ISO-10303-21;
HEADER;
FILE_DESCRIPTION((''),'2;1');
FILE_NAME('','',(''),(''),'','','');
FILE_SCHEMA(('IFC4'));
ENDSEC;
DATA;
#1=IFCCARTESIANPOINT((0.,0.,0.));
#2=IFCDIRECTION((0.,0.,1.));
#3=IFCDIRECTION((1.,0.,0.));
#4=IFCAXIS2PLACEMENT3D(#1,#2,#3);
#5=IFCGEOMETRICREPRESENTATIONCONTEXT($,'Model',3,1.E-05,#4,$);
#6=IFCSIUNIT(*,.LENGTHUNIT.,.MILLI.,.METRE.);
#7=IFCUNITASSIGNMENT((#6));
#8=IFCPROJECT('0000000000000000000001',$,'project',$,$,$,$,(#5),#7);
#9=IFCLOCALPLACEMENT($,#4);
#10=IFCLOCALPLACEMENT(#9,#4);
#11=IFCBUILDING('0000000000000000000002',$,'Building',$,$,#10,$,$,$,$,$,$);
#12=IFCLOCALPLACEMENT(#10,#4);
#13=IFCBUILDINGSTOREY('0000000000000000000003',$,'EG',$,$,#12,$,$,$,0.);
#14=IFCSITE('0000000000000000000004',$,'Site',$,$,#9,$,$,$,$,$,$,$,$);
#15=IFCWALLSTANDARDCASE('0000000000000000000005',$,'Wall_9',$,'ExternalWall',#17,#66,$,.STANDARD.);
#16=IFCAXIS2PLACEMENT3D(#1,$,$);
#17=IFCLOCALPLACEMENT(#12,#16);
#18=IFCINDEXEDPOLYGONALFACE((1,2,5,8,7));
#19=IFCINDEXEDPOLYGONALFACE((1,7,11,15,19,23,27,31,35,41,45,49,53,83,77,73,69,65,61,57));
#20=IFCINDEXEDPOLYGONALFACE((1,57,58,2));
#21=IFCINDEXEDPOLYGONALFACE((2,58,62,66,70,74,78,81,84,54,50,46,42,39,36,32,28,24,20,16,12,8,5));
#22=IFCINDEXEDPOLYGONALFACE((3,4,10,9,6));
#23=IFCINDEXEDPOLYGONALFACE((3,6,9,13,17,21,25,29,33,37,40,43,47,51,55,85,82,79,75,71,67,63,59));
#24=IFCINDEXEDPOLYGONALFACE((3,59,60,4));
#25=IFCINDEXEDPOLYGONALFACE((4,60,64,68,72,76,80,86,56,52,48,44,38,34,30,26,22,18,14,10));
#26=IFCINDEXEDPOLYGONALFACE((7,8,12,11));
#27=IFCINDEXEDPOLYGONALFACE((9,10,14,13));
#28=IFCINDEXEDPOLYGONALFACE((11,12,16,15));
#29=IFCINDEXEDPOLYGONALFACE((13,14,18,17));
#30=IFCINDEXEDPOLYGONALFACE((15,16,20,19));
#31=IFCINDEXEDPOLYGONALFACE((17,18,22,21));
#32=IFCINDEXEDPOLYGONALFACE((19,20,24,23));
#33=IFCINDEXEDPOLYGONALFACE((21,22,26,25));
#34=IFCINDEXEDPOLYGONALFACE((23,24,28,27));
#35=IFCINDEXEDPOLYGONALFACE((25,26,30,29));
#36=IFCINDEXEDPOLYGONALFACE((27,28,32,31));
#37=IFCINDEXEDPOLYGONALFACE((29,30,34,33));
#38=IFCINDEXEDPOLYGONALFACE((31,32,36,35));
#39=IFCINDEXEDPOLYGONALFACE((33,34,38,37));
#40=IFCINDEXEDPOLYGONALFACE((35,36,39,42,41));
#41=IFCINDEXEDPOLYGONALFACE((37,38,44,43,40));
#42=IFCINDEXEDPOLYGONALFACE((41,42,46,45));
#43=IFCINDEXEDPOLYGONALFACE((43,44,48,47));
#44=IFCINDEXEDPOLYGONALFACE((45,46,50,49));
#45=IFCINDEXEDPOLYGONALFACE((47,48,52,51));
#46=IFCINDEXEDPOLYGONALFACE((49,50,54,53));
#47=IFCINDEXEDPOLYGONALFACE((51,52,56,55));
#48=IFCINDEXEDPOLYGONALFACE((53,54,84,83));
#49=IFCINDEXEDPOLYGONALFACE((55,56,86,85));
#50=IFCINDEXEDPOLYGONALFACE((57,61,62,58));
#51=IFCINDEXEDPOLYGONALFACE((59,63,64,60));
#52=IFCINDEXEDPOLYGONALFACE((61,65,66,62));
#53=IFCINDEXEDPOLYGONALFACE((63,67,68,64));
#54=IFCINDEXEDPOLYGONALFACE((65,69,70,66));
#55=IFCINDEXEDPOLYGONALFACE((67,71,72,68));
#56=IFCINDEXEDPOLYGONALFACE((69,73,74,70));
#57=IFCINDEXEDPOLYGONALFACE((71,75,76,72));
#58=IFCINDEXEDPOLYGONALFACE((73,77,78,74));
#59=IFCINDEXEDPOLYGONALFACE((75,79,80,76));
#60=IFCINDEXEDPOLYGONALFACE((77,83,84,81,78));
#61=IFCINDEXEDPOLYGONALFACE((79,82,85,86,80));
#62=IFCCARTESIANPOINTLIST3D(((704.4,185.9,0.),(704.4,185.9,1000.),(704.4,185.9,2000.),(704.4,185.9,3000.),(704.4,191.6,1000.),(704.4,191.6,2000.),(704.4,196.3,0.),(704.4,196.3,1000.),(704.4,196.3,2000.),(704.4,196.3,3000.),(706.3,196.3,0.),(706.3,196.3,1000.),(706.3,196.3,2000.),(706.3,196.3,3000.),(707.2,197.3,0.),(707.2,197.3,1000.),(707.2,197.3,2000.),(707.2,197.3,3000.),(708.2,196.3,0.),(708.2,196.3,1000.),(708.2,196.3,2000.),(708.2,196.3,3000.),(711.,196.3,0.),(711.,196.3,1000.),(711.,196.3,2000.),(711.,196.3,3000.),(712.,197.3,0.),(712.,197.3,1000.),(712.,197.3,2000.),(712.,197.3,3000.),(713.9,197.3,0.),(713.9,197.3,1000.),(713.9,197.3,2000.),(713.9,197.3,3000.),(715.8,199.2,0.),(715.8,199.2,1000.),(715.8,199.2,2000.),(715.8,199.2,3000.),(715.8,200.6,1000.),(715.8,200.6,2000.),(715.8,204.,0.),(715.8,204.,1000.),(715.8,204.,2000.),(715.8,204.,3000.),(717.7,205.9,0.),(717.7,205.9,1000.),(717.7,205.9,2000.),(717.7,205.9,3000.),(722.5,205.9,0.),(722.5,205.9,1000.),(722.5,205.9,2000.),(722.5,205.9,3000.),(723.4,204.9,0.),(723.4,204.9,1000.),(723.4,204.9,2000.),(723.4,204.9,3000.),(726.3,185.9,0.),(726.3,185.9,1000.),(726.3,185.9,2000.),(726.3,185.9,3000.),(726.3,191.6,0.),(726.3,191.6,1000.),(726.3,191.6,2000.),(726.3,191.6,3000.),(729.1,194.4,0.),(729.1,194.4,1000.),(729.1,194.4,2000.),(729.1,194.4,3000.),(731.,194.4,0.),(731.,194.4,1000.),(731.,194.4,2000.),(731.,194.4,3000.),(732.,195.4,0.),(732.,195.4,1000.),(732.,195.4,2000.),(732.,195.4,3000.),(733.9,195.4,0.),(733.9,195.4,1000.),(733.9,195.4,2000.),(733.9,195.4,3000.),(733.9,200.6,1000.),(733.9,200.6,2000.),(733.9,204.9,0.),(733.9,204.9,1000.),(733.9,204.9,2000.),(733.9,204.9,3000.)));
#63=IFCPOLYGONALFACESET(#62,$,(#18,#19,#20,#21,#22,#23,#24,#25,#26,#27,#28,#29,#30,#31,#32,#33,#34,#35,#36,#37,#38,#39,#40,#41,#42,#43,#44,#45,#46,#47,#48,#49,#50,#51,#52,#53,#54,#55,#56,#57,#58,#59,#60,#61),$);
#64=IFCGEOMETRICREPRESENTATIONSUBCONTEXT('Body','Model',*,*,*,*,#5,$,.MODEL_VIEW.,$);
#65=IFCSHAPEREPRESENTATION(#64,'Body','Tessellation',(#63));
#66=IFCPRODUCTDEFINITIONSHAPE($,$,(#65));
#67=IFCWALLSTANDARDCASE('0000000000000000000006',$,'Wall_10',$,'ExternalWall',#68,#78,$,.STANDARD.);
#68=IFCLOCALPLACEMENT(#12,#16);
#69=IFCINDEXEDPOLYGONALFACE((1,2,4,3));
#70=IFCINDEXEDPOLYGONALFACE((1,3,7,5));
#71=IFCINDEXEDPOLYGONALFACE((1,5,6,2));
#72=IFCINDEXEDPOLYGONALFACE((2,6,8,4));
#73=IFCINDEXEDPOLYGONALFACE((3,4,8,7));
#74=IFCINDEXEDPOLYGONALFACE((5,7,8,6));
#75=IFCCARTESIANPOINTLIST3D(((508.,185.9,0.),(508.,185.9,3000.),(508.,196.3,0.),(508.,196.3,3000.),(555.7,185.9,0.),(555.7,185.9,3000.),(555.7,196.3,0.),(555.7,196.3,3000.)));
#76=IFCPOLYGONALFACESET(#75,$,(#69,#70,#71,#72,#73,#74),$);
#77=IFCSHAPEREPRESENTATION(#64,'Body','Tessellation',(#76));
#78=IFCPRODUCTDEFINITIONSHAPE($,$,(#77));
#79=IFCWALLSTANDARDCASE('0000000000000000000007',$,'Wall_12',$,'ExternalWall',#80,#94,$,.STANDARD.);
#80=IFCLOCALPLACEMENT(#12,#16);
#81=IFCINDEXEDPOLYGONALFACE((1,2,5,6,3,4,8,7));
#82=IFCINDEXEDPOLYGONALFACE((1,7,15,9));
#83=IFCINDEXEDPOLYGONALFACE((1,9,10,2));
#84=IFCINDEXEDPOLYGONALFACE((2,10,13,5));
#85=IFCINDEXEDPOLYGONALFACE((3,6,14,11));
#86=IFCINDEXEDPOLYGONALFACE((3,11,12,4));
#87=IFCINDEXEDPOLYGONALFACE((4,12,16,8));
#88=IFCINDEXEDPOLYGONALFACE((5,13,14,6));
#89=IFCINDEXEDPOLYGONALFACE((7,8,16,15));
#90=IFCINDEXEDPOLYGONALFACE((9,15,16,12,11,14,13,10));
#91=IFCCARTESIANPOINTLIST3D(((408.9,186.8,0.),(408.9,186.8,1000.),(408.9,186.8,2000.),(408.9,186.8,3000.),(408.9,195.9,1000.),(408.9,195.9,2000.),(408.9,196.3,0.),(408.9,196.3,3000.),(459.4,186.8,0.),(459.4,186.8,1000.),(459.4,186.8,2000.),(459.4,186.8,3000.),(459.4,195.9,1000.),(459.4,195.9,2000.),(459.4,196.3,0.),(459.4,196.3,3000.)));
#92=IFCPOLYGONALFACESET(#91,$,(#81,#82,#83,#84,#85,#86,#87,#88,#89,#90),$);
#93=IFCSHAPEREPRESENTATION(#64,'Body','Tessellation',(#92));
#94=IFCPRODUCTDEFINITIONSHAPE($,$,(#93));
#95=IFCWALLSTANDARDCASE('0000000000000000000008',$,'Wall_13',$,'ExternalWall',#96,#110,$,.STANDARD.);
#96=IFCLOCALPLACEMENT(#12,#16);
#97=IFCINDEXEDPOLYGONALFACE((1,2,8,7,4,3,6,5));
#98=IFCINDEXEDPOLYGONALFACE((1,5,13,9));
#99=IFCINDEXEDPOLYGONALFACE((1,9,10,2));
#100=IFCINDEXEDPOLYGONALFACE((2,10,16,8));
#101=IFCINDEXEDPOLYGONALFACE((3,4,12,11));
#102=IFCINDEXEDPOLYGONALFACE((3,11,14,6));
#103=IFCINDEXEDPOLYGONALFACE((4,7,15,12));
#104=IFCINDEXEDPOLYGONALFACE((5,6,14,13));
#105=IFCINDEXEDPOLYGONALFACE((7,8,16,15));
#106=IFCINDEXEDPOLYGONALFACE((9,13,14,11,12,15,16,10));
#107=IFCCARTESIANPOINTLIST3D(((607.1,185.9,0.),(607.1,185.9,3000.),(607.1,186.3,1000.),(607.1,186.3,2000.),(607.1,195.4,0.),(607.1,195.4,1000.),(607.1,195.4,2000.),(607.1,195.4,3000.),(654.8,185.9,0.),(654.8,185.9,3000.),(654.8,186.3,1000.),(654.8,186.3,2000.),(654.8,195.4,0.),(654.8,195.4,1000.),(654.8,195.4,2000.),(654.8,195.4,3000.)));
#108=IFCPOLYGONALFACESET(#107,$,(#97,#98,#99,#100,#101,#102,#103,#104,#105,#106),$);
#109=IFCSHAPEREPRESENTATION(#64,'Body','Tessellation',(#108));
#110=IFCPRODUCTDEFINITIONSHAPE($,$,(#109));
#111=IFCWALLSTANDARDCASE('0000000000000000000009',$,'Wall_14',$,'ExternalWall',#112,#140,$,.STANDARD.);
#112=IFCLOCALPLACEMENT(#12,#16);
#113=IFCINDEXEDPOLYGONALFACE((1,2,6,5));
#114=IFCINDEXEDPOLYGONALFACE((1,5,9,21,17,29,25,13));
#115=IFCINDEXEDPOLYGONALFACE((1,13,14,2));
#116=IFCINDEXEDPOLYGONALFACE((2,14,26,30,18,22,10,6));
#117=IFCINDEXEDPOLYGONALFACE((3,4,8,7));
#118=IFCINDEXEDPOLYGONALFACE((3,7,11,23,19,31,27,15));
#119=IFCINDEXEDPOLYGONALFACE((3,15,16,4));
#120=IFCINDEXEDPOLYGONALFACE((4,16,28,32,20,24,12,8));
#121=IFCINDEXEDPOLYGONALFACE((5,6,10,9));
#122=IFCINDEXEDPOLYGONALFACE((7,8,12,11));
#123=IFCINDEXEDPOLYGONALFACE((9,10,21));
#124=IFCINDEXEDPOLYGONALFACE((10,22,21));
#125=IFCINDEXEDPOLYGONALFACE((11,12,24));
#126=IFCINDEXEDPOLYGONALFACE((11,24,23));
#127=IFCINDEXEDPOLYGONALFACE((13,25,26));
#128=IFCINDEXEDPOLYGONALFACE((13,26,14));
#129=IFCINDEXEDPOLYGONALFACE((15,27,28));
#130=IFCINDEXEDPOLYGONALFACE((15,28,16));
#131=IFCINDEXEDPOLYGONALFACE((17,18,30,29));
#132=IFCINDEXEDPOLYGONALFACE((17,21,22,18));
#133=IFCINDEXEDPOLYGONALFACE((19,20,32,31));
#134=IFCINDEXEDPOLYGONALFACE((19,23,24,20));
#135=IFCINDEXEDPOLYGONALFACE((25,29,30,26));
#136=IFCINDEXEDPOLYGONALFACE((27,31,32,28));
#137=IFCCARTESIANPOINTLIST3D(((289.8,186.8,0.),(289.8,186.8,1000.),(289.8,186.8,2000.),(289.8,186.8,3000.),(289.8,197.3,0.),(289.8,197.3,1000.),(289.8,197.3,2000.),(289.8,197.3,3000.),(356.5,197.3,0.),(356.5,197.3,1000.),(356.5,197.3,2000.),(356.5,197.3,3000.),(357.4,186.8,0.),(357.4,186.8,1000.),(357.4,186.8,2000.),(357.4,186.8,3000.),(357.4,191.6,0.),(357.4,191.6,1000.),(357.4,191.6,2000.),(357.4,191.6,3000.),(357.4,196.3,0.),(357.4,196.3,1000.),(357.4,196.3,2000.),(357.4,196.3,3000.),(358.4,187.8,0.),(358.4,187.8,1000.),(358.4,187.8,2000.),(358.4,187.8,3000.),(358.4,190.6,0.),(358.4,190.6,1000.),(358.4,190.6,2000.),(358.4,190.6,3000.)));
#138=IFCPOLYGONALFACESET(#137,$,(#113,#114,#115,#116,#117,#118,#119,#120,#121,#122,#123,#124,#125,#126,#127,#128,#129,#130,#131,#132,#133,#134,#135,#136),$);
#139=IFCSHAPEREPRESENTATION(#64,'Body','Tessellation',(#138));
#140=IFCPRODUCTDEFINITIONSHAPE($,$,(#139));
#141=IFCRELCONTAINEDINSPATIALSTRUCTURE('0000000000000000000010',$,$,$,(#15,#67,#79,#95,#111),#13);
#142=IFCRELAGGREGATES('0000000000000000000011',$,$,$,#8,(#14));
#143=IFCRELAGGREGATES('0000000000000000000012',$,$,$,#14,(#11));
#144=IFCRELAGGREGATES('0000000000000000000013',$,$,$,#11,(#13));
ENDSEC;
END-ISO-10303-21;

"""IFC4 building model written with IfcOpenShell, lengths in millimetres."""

from ifc_helpers import new_model, si_unit, frame, origin_with_axes, place, context, subcontext, project, spatial, polyline, rectangle, outline, extrude, element, save


model = new_model("IFC4")

# Units and contexts
model_context = context("Model", 3, precision=1e-05, world=origin_with_axes())
body_context = subcontext(model_context, "Body", "Model", "MODEL_VIEW")
ifc_project = project(units=[si_unit("LENGTHUNIT", "METRE", prefix="MILLI")], contexts=[model_context])

# Site, building, storey
site_placement = place(None, origin_with_axes())
site = spatial("IfcSite", under=ifc_project, at=site_placement, Name="Site")
building_placement = place(site_placement, origin_with_axes())
building = spatial("IfcBuilding", under=site, at=building_placement, Name="Building")
storey_placement = place(building_placement, origin_with_axes())
storey = spatial("IfcBuildingStorey", under=building, at=storey_placement, Name="EG", Elevation=0.0)

# Wall, openings
wall_1_placement = place(storey_placement, origin_with_axes())
wall_1 = element("IfcWallStandardCase", 1, at=wall_1_placement, inside=storey, Name="Wall_9", ObjectType="ExternalWall", PredefinedType="STANDARD", context=body_context, shape_type="SweptSolid", body=[
    extrude(outline(polyline([(704.4, 185.9, 0.0), (704.4, 196.3, 0.0), (706.3, 196.3, 0.0), (707.2, 197.3, 0.0), (708.2, 196.3, 0.0), (711.0, 196.3, 0.0), (712.0, 197.3, 0.0), (713.9, 197.3, 0.0), (715.8, 199.2, 0.0), (715.8, 204.0, 0.0), (717.7, 205.9, 0.0), (722.5, 205.9, 0.0), (723.4, 204.9, 0.0), (733.9, 204.9, 0.0), (733.9, 195.4, 0.0), (732.0, 195.4, 0.0), (731.0, 194.4, 0.0), (729.1, 194.4, 0.0), (726.3, 191.6, 0.0), (726.3, 185.9, 0.0), (704.4, 185.9, 0.0)])), origin_with_axes(), (0.0, 0.0, 1.0), 3000.0),
])
opening_1_placement = place(wall_1_placement, origin_with_axes())
element("IfcOpeningElement", 2, at=opening_1_placement, inside=storey, cuts=wall_1, context=body_context, shape_type="SweptSolid", body=[
    extrude(rectangle(XDim=1200.0, YDim=20.0), frame((680.1, 190.6, 1000.0), z_axis=(0.0, 0.0, 1.0), x_axis=(1.0, 0.0, 0.0)), (0.0, 0.0, 1.0), 1000.0),
])
opening_2_placement = place(wall_1_placement, origin_with_axes())
element("IfcOpeningElement", 3, at=opening_2_placement, inside=storey, cuts=wall_1, context=body_context, shape_type="SweptSolid", body=[
    extrude(rectangle(XDim=1200.0, YDim=20.0), frame((798.7, 201.6, 1000.0), z_axis=(0.0, 0.0, 1.0), x_axis=(1.0, 0.0, 0.0)), (0.0, 0.0, 1.0), 1000.0),
])

# Wall
wall_2_placement = place(storey_placement, origin_with_axes())
element("IfcWallStandardCase", 4, at=wall_2_placement, inside=storey, Name="Wall_10", ObjectType="ExternalWall", PredefinedType="STANDARD", context=body_context, shape_type="SweptSolid", body=[
    extrude(outline(polyline([(508.0, 185.9, 0.0), (508.0, 196.3, 0.0), (555.7, 196.3, 0.0), (555.7, 185.9, 0.0), (508.0, 185.9, 0.0)])), origin_with_axes(), (0.0, 0.0, 1.0), 3000.0),
])

# Walls, openings
wall_3_placement = place(storey_placement, origin_with_axes())
wall_3 = element("IfcWallStandardCase", 5, at=wall_3_placement, inside=storey, Name="Wall_12", ObjectType="ExternalWall", PredefinedType="STANDARD", context=body_context, shape_type="SweptSolid", body=[
    extrude(outline(polyline([(408.9, 186.8, 0.0), (408.9, 196.3, 0.0), (459.4, 196.3, 0.0), (459.4, 186.8, 0.0), (408.9, 186.8, 0.0)])), origin_with_axes(), (0.0, 0.0, 1.0), 3000.0),
])
opening_3_placement = place(wall_3_placement, origin_with_axes())
element("IfcOpeningElement", 6, at=opening_3_placement, inside=storey, cuts=wall_3, context=body_context, shape_type="SweptSolid", body=[
    extrude(rectangle(XDim=1200.0, YDim=9.5), frame((483.0, 191.1, 1000.0), z_axis=(0.0, 0.0, 1.0), x_axis=(1.0, 0.0, 0.0)), (0.0, 0.0, 1.0), 1000.0),
])
wall_4_placement = place(storey_placement, origin_with_axes())
wall_4 = element("IfcWallStandardCase", 7, at=wall_4_placement, inside=storey, Name="Wall_13", ObjectType="ExternalWall", PredefinedType="STANDARD", context=body_context, shape_type="SweptSolid", body=[
    extrude(outline(polyline([(607.1, 185.9, 0.0), (607.1, 195.4, 0.0), (654.8, 195.4, 0.0), (654.8, 185.9, 0.0), (607.1, 185.9, 0.0)])), origin_with_axes(), (0.0, 0.0, 1.0), 3000.0),
])
opening_4_placement = place(wall_4_placement, origin_with_axes())
element("IfcOpeningElement", 8, at=opening_4_placement, inside=storey, cuts=wall_4, context=body_context, shape_type="SweptSolid", body=[
    extrude(rectangle(XDim=1200.0, YDim=9.5), frame((582.2, 191.1, 1000.0), z_axis=(0.0, 0.0, 1.0), x_axis=(1.0, 0.0, 0.0)), (0.0, 0.0, 1.0), 1000.0),
])
wall_5_placement = place(storey_placement, origin_with_axes())
wall_5 = element("IfcWallStandardCase", 9, at=wall_5_placement, inside=storey, Name="Wall_14", ObjectType="ExternalWall", PredefinedType="STANDARD", context=body_context, shape_type="SweptSolid", body=[
    extrude(outline(polyline([(289.8, 186.8, 0.0), (289.8, 197.3, 0.0), (356.5, 197.3, 0.0), (357.4, 196.3, 0.0), (357.4, 191.6, 0.0), (358.4, 190.6, 0.0), (358.4, 187.8, 0.0), (357.4, 186.8, 0.0), (289.8, 186.8, 0.0)])), origin_with_axes(), (0.0, 0.0, 1.0), 3000.0),
])
opening_5_placement = place(wall_5_placement, origin_with_axes())
element("IfcOpeningElement", 10, at=opening_5_placement, inside=storey, cuts=wall_5, context=body_context, shape_type="SweptSolid", body=[
    extrude(rectangle(XDim=1200.0, YDim=10.5), frame((383.1, 192.1, 1000.0), z_axis=(0.0, 0.0, 1.0), x_axis=(1.0, 0.0, 0.0)), (0.0, 0.0, 1.0), 1000.0),
])

save(model, "model.ifc")
